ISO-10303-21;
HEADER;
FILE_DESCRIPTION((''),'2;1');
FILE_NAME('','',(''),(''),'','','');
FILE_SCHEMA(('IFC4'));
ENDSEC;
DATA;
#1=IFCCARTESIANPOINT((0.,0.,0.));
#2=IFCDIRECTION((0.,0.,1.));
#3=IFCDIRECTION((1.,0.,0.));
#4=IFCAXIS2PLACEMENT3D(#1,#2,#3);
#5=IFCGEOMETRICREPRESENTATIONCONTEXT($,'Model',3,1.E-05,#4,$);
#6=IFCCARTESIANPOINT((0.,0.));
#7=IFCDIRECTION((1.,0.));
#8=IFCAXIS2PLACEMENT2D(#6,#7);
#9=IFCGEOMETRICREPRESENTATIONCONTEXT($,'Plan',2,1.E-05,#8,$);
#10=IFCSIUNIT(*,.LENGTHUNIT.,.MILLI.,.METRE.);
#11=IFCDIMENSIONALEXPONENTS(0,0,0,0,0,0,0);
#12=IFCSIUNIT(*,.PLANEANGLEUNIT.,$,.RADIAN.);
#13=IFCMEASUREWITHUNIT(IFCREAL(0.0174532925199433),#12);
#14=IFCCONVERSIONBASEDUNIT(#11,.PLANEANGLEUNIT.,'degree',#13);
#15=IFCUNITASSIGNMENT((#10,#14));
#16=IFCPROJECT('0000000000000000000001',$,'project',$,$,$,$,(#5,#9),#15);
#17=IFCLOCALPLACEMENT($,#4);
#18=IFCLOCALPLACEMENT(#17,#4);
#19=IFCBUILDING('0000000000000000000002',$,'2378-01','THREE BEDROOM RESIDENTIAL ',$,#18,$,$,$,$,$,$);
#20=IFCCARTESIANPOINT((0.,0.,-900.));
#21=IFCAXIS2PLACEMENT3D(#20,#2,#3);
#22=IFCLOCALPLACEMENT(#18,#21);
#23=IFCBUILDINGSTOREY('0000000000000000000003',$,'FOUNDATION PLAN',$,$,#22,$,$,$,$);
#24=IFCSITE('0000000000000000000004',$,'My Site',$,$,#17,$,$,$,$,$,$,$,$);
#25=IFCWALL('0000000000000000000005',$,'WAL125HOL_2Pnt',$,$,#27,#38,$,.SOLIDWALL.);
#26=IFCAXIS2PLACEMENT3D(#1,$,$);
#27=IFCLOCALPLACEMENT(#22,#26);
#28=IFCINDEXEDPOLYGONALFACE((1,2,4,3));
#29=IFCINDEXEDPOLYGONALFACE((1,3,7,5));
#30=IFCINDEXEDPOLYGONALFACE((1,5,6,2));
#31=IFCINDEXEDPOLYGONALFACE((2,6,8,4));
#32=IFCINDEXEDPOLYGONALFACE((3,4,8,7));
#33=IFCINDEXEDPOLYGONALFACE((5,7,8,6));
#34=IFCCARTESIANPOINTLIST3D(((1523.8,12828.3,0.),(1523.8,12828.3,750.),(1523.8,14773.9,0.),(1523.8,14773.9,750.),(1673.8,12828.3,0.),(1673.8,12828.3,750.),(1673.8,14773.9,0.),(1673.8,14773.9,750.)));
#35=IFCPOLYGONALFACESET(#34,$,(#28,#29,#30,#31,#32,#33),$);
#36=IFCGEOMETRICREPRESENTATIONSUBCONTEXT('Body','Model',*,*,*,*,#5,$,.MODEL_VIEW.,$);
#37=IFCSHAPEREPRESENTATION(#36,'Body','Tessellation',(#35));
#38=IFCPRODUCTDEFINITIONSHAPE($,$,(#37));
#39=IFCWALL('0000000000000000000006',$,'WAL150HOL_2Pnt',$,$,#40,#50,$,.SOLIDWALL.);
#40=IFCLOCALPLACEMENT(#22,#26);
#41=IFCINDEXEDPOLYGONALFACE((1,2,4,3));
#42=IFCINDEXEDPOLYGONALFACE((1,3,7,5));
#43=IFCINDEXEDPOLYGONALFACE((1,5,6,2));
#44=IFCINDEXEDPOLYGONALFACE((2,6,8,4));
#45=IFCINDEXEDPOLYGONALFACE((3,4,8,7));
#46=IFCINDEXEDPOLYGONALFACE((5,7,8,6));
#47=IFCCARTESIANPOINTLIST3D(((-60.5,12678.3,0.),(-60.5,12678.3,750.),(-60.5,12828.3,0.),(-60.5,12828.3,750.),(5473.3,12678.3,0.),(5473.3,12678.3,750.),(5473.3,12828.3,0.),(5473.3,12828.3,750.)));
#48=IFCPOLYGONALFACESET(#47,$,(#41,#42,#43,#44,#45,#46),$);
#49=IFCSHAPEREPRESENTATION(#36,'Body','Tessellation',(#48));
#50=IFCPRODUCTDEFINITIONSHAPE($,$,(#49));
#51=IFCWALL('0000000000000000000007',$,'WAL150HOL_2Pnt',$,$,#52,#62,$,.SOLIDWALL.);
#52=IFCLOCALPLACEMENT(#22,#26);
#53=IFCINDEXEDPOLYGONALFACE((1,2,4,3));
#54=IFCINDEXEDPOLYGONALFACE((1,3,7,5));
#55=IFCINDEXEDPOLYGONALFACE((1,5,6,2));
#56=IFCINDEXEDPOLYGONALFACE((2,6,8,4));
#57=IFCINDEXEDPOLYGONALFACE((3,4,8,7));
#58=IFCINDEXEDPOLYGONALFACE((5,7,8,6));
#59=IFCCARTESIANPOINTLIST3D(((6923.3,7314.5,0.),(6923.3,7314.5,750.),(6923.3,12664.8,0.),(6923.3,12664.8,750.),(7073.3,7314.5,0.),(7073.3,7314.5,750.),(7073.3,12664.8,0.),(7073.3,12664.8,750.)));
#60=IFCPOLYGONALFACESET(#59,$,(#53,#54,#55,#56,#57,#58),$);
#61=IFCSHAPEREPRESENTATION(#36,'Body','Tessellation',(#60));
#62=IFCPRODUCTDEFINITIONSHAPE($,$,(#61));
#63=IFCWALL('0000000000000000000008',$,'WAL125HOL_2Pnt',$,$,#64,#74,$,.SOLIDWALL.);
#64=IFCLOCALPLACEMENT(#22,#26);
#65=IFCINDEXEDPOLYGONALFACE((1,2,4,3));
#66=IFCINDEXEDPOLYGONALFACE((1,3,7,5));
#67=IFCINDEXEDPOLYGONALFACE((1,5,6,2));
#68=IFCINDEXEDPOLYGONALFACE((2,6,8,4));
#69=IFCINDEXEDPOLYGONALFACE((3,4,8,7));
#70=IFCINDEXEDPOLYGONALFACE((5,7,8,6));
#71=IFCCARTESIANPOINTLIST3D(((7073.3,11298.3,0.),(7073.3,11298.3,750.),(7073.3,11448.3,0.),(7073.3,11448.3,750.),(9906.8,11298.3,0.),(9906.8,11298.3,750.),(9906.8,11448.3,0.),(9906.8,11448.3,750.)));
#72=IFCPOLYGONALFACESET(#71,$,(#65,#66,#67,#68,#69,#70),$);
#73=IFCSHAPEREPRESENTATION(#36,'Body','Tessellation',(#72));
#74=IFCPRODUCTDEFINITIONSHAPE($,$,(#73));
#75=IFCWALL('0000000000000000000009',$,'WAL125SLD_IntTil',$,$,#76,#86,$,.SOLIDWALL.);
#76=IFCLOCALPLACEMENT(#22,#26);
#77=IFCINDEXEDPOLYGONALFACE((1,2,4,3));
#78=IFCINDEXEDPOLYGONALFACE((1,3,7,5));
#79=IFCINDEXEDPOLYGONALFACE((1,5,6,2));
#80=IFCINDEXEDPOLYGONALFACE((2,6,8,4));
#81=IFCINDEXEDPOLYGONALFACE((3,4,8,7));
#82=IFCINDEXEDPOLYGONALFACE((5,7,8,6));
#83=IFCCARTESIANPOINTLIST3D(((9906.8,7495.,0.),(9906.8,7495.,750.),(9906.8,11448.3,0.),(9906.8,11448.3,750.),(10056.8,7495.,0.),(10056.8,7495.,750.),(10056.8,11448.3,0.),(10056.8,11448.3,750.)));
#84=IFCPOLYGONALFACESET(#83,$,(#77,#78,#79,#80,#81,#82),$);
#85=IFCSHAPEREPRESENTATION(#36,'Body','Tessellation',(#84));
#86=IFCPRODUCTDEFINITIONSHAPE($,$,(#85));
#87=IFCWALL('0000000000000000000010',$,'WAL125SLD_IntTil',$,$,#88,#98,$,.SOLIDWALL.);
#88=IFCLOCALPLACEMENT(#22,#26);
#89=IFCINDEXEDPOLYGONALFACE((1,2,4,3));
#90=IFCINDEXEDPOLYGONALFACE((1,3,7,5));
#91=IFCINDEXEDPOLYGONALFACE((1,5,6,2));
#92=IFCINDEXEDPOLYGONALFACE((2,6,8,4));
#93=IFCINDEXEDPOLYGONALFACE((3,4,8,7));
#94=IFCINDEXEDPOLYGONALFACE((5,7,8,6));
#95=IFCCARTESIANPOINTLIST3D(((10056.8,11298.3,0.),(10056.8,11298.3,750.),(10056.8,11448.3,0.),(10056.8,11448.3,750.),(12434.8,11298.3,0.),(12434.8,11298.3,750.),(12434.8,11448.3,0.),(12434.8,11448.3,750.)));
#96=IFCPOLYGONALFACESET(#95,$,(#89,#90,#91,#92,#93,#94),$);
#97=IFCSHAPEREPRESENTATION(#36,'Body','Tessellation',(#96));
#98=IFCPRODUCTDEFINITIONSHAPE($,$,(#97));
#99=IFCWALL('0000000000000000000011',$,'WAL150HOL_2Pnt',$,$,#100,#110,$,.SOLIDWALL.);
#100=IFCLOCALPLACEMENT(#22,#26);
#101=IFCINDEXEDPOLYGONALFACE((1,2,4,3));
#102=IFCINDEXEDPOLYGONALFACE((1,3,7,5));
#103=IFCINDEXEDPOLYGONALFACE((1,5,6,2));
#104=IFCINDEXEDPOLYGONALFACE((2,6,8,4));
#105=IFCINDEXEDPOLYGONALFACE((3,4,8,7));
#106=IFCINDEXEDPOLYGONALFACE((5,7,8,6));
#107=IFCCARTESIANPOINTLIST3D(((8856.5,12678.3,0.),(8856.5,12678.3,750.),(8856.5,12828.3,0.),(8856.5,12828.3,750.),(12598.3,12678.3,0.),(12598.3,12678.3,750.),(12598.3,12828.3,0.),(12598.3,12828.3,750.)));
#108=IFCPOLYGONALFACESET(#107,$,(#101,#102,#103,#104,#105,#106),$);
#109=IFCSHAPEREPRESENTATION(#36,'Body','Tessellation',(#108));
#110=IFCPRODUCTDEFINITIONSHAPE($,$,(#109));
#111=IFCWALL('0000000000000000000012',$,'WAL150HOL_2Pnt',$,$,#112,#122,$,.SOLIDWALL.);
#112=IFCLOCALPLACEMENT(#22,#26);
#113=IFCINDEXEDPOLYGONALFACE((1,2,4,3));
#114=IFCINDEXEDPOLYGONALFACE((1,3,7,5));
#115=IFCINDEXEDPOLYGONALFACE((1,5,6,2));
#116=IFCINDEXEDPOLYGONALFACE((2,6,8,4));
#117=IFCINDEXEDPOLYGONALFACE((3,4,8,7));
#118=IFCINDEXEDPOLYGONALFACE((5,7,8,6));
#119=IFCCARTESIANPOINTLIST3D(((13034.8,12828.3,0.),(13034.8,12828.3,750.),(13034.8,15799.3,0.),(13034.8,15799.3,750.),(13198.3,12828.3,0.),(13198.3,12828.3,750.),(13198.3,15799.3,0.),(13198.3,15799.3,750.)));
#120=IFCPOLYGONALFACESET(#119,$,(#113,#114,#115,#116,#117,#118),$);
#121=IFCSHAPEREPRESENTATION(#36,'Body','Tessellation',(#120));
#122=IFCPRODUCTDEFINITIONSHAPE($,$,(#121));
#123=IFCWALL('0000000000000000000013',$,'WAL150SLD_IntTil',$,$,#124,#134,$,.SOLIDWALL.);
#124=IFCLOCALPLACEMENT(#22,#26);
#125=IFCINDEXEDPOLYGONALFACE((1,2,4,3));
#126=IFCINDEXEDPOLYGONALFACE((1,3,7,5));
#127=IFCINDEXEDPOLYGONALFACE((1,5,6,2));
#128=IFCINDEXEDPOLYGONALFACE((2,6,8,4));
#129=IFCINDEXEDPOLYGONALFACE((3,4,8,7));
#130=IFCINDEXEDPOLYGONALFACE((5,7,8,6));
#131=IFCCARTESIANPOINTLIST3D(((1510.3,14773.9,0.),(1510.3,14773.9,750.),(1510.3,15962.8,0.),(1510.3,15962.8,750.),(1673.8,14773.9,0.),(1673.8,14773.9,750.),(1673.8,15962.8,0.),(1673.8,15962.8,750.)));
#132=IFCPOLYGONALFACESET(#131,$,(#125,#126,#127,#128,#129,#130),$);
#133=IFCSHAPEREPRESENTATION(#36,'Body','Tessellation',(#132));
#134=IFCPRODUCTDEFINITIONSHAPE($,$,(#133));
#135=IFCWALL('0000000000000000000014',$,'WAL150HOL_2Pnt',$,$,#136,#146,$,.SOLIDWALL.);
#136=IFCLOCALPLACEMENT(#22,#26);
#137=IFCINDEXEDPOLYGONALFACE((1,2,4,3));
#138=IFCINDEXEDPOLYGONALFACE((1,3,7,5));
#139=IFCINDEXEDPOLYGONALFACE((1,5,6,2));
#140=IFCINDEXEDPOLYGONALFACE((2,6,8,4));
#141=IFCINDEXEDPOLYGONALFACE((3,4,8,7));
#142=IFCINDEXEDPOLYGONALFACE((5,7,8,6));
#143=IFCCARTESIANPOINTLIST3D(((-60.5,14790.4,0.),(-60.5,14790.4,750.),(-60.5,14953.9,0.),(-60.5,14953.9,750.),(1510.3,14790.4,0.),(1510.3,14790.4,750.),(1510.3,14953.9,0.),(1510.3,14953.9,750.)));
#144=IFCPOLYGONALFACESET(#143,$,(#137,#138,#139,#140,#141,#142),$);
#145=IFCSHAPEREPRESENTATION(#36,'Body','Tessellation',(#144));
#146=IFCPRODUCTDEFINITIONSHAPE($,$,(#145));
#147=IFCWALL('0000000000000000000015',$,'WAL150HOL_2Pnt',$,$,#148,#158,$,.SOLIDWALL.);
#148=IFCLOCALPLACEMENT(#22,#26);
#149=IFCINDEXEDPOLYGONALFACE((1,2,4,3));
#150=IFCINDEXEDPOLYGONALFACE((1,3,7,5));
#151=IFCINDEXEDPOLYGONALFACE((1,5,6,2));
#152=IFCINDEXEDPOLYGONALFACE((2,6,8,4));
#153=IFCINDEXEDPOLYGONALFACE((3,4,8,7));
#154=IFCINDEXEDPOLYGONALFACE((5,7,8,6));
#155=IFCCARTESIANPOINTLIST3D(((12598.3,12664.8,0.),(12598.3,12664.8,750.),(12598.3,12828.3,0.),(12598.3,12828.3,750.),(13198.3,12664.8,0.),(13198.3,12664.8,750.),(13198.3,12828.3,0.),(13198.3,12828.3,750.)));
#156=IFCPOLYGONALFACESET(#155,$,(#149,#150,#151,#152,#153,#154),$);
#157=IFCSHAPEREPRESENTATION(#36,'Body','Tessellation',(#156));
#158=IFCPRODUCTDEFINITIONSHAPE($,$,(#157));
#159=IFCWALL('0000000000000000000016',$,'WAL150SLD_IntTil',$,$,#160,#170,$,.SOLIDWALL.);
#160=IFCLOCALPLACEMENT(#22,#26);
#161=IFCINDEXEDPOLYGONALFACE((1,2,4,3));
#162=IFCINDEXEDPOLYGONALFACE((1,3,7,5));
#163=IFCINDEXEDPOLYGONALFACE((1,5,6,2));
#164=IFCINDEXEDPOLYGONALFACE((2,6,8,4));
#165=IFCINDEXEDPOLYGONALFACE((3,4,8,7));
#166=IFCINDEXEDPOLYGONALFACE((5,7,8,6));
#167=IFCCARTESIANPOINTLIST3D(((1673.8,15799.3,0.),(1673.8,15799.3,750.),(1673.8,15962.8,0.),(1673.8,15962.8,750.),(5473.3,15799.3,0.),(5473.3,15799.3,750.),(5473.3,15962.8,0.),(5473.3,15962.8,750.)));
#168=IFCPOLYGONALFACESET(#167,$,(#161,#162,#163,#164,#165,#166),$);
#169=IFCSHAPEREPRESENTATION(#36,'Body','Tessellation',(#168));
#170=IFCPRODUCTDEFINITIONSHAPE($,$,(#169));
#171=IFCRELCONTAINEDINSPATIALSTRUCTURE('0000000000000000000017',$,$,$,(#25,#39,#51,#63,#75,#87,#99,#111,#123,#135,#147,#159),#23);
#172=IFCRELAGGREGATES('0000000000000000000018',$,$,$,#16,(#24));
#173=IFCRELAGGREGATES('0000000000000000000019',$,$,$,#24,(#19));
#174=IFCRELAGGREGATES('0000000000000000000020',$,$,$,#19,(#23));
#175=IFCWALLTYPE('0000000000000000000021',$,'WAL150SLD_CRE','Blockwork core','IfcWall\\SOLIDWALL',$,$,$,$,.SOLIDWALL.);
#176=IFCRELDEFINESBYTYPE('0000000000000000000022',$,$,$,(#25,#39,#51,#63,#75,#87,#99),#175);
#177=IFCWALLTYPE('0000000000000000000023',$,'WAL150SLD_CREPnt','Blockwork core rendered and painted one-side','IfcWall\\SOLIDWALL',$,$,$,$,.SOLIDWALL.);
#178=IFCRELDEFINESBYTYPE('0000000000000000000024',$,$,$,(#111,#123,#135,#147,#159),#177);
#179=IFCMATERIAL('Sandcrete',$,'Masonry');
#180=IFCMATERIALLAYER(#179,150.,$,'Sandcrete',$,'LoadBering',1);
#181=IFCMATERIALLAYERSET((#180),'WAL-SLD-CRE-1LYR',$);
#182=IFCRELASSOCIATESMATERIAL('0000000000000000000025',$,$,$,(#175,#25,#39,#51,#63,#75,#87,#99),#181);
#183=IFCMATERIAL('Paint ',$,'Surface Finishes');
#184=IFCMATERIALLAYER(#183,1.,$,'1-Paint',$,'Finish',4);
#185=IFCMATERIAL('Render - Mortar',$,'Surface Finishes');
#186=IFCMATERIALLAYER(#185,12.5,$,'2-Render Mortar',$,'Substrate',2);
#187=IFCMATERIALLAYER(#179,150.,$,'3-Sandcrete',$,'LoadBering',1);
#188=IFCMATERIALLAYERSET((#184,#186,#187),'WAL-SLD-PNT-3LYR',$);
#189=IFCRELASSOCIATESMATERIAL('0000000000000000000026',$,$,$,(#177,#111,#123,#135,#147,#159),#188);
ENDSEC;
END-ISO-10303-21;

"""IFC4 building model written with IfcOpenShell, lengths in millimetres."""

from ifc_helpers import new_model, entity, si_unit, converted_unit, frame, origin_with_axes, origin_2d_with_axis, place, context, subcontext, project, spatial, indexed_curve, outline, extrude, material, layer, layer_set, layer_usage, type_object, element, save


model = new_model("IFC4")

# Units and contexts
model_context = context("Model", 3, precision=1e-05, world=origin_with_axes())
plan_context = context("Plan", 2, precision=1e-05, world=origin_2d_with_axis())
body_context = subcontext(model_context, "Body", "Model", "MODEL_VIEW")
ifc_project = project(units=[si_unit("LENGTHUNIT", "METRE", prefix="MILLI"), converted_unit("PLANEANGLEUNIT", "degree", entity("IfcReal", 0.0174532925199433), si_unit("PLANEANGLEUNIT", "RADIAN"), dimensions=[0, 0, 0, 0, 0, 0, 0])], contexts=[model_context, plan_context])

# Site, building, storey
site_placement = place(None, origin_with_axes())
site = spatial("IfcSite", under=ifc_project, at=site_placement, Name="My Site")
building_placement = place(site_placement, origin_with_axes())
building = spatial("IfcBuilding", under=site, at=building_placement, Name="2378-01", Description="THREE BEDROOM RESIDENTIAL ")
storey_placement = place(building_placement, frame((0.0, 0.0, -900.0), z_axis=(0.0, 0.0, 1.0), x_axis=(1.0, 0.0, 0.0)))
storey = spatial("IfcBuildingStorey", under=building, at=storey_placement, Name="FOUNDATION PLAN")

# Walls
ifc_material_1 = material(Name="Sandcrete", Category="Masonry")
ifc_layer_1 = layer(ifc_material_1, 150.0, Name="Sandcrete", Category="LoadBering", Priority=1)
ifc_layer_set_1 = layer_set([ifc_layer_1], Name="WAL-SLD-CRE-1LYR")
ifc_layer_usage_1 = layer_usage(ifc_layer_set_1, "AXIS2", "POSITIVE", 0.0)
wall_type_1 = type_object("IfcWallType", Name="WAL150SLD_CRE", Description="Blockwork core", ApplicableOccurrence="IfcWall\\SOLIDWALL", PredefinedType="SOLIDWALL", material=ifc_layer_set_1)
wall_1_placement = place(storey_placement, frame((1523.8, 14773.9, 0.0), z_axis=(0.0, 0.0, 1.0), x_axis=(-0.000001, -1.0, 0.0)))
element("IfcWall", 1, at=wall_1_placement, inside=storey, type_object=wall_type_1, material=ifc_layer_usage_1, Name="WAL125HOL_2Pnt", PredefinedType="SOLIDWALL", context=body_context, shape_type="SweptSolid", body=[
    extrude(outline(indexed_curve([(0.0, 0.0), (0.0, 150.0), (1945.6, 150.0), (1945.6, 0.0), (0.0, 0.0)], self_intersect=False)), origin_with_axes(), (0.0, 0.0, 1.0), 750.0),
])
ifc_layer_usage_2 = layer_usage(ifc_layer_set_1, "AXIS2", "POSITIVE", 0.0)
wall_2_placement = place(storey_placement, frame((5473.3, 12828.3, 0.0), z_axis=(0.0, 0.0, 1.0), x_axis=(-1.0, 0.0, 0.0)))
element("IfcWall", 2, at=wall_2_placement, inside=storey, type_object=wall_type_1, material=ifc_layer_usage_2, Name="WAL150HOL_2Pnt", PredefinedType="SOLIDWALL", context=body_context, shape_type="SweptSolid", body=[
    extrude(outline(indexed_curve([(0.0, 0.0), (0.0, 150.0), (5533.8, 150.0), (5533.8, 0.0), (0.0, 0.0)], self_intersect=False)), origin_with_axes(), (0.0, 0.0, 1.0), 750.0),
])
ifc_layer_usage_3 = layer_usage(ifc_layer_set_1, "AXIS2", "POSITIVE", 0.0)
wall_3_placement = place(storey_placement, frame((6923.3, 12664.8, 0.0), z_axis=(0.0, 0.0, 1.0), x_axis=(-0.000001, -1.0, 0.0)))
element("IfcWall", 3, at=wall_3_placement, inside=storey, type_object=wall_type_1, material=ifc_layer_usage_3, Name="WAL150HOL_2Pnt", PredefinedType="SOLIDWALL", context=body_context, shape_type="SweptSolid", body=[
    extrude(outline(indexed_curve([(0.0, 0.0), (0.0, 150.0), (5350.3, 150.0), (5350.3, 0.0), (0.0, 0.0)], self_intersect=False)), origin_with_axes(), (0.0, 0.0, 1.0), 750.0),
])
ifc_layer_usage_4 = layer_usage(ifc_layer_set_1, "AXIS2", "POSITIVE", 0.0)
wall_4_placement = place(storey_placement, frame((7073.3, 11298.3, 0.0), z_axis=(0.0, 0.0, 1.0), x_axis=(1.0, -0.000002, 0.0)))
element("IfcWall", 4, at=wall_4_placement, inside=storey, type_object=wall_type_1, material=ifc_layer_usage_4, Name="WAL125HOL_2Pnt", PredefinedType="SOLIDWALL", context=body_context, shape_type="SweptSolid", body=[
    extrude(outline(indexed_curve([(0.0, 0.0), (0.0, 150.0), (2833.5, 150.0), (2833.5, 0.0), (0.0, 0.0)], self_intersect=False)), origin_with_axes(), (0.0, 0.0, 1.0), 750.0),
])
ifc_layer_usage_5 = layer_usage(ifc_layer_set_1, "AXIS2", "POSITIVE", 0.0)
wall_5_placement = place(storey_placement, frame((9906.8, 11448.3, 0.0), z_axis=(0.0, 0.0, 1.0), x_axis=(-0.000001, -1.0, 0.0)))
element("IfcWall", 5, at=wall_5_placement, inside=storey, type_object=wall_type_1, material=ifc_layer_usage_5, Name="WAL125SLD_IntTil", PredefinedType="SOLIDWALL", context=body_context, shape_type="SweptSolid", body=[
    extrude(outline(indexed_curve([(0.0, 0.0), (0.0, 150.0), (3953.3, 150.0), (3953.3, 0.0), (0.0, 0.0)], self_intersect=False)), origin_with_axes(), (0.0, 0.0, 1.0), 750.0),
])
ifc_layer_usage_6 = layer_usage(ifc_layer_set_1, "AXIS2", "POSITIVE", 0.0)
wall_6_placement = place(storey_placement, frame((10056.8, 11298.3, 0.0), z_axis=(0.0, 0.0, 1.0), x_axis=(1.0, -0.000001, 0.0)))
element("IfcWall", 6, at=wall_6_placement, inside=storey, type_object=wall_type_1, material=ifc_layer_usage_6, Name="WAL125SLD_IntTil", PredefinedType="SOLIDWALL", context=body_context, shape_type="SweptSolid", body=[
    extrude(outline(indexed_curve([(0.0, 0.0), (0.0, 150.0), (2378.0, 150.0), (2378.0, 0.0), (0.0, 0.0)], self_intersect=False)), origin_with_axes(), (0.0, 0.0, 1.0), 750.0),
])
ifc_layer_usage_7 = layer_usage(ifc_layer_set_1, "AXIS2", "POSITIVE", 0.0)
wall_7_placement = place(storey_placement, frame((12598.3, 12828.3, 0.0), z_axis=(0.0, 0.0, 1.0), x_axis=(-1.0, 0.000001, 0.0)))
element("IfcWall", 7, at=wall_7_placement, inside=storey, type_object=wall_type_1, material=ifc_layer_usage_7, Name="WAL150HOL_2Pnt", PredefinedType="SOLIDWALL", context=body_context, shape_type="SweptSolid", body=[
    extrude(outline(indexed_curve([(0.0, 0.0), (0.0, 150.0), (3741.8, 150.0), (3741.8, 0.0), (0.0, 0.0)], self_intersect=False)), origin_with_axes(), (0.0, 0.0, 1.0), 750.0),
])
ifc_material_2 = material(Name="Paint ", Category="Surface Finishes")
ifc_layer_2 = layer(ifc_material_2, 1.0, Name="1-Paint", Category="Finish", Priority=4)
ifc_material_3 = material(Name="Render - Mortar", Category="Surface Finishes")
ifc_layer_3 = layer(ifc_material_3, 12.5, Name="2-Render Mortar", Category="Substrate", Priority=2)
ifc_layer_4 = layer(ifc_material_1, 150.0, Name="3-Sandcrete", Category="LoadBering", Priority=1)
ifc_layer_set_2 = layer_set([ifc_layer_2, ifc_layer_3, ifc_layer_4], Name="WAL-SLD-PNT-3LYR")
ifc_layer_usage_8 = layer_usage(ifc_layer_set_2, "AXIS2", "POSITIVE", 0.0)
wall_type_2 = type_object("IfcWallType", Name="WAL150SLD_CREPnt", Description="Blockwork core rendered and painted one-side", ApplicableOccurrence="IfcWall\\SOLIDWALL", PredefinedType="SOLIDWALL", material=ifc_layer_set_2)
wall_8_placement = place(storey_placement, frame((13198.3, 12828.3, 0.0), z_axis=(0.0, 0.0, 1.0), x_axis=(0.000001, 1.0, 0.0)))
element("IfcWall", 8, at=wall_8_placement, inside=storey, type_object=wall_type_2, material=ifc_layer_usage_8, Name="WAL150HOL_2Pnt", PredefinedType="SOLIDWALL", context=body_context, shape_type="SweptSolid", body=[
    extrude(outline(indexed_curve([(0.0, 0.0), (0.0, 163.5), (2971.0, 163.5), (2971.0, 0.0), (0.0, 0.0)], self_intersect=False)), origin_with_axes(), (0.0, 0.0, 1.0), 750.0),
])
ifc_layer_usage_9 = layer_usage(ifc_layer_set_2, "AXIS2", "POSITIVE", 0.0)
wall_9_placement = place(storey_placement, frame((1510.3, 15962.8, 0.0), z_axis=(0.0, 0.0, 1.0), x_axis=(-0.000001, -1.0, 0.0)))
element("IfcWall", 9, at=wall_9_placement, inside=storey, type_object=wall_type_2, material=ifc_layer_usage_9, Name="WAL150SLD_IntTil", PredefinedType="SOLIDWALL", context=body_context, shape_type="SweptSolid", body=[
    extrude(outline(indexed_curve([(0.0, 0.0), (0.0, 163.5), (1188.9, 163.5), (1188.9, 0.0), (0.0, 0.0)], self_intersect=False)), origin_with_axes(), (0.0, 0.0, 1.0), 750.0),
])
ifc_layer_usage_10 = layer_usage(ifc_layer_set_2, "AXIS2", "POSITIVE", 0.0)
wall_10_placement = place(storey_placement, frame((1510.3, 14953.9, 0.0), z_axis=(0.0, 0.0, 1.0), x_axis=(-1.0, 0.0, 0.0)))
element("IfcWall", 10, at=wall_10_placement, inside=storey, type_object=wall_type_2, material=ifc_layer_usage_10, Name="WAL150HOL_2Pnt", PredefinedType="SOLIDWALL", context=body_context, shape_type="SweptSolid", body=[
    extrude(outline(indexed_curve([(0.0, 0.0), (0.0, 163.5), (1570.8, 163.5), (1570.8, 0.0), (0.0, 0.0)], self_intersect=False)), origin_with_axes(), (0.0, 0.0, 1.0), 750.0),
])
ifc_layer_usage_11 = layer_usage(ifc_layer_set_2, "AXIS2", "POSITIVE", 0.0)
wall_11_placement = place(storey_placement, frame((12598.3, 12664.8, 0.0), z_axis=(0.0, 0.0, 1.0), x_axis=(1.0, -0.000001, 0.0)))
element("IfcWall", 11, at=wall_11_placement, inside=storey, type_object=wall_type_2, material=ifc_layer_usage_11, Name="WAL150HOL_2Pnt", PredefinedType="SOLIDWALL", context=body_context, shape_type="SweptSolid", body=[
    extrude(outline(indexed_curve([(0.0, 0.0), (0.0, 163.5), (600.0, 163.5), (600.0, 0.0), (0.0, 0.0)], self_intersect=False)), origin_with_axes(), (0.0, 0.0, 1.0), 750.0),
])
ifc_layer_usage_12 = layer_usage(ifc_layer_set_2, "AXIS2", "POSITIVE", 0.0)
wall_12_placement = place(storey_placement, frame((5473.3, 15962.8, 0.0), z_axis=(0.0, 0.0, 1.0), x_axis=(-1.0, 0.000001, 0.0)))
element("IfcWall", 12, at=wall_12_placement, inside=storey, type_object=wall_type_2, material=ifc_layer_usage_12, Name="WAL150SLD_IntTil", PredefinedType="SOLIDWALL", context=body_context, shape_type="SweptSolid", body=[
    extrude(outline(indexed_curve([(0.0, 0.0), (0.0, 163.5), (3799.5, 163.5), (3799.5, 0.0), (0.0, 0.0)], self_intersect=False)), origin_with_axes(), (0.0, 0.0, 1.0), 750.0),
])

save(model, "model.ifc")
